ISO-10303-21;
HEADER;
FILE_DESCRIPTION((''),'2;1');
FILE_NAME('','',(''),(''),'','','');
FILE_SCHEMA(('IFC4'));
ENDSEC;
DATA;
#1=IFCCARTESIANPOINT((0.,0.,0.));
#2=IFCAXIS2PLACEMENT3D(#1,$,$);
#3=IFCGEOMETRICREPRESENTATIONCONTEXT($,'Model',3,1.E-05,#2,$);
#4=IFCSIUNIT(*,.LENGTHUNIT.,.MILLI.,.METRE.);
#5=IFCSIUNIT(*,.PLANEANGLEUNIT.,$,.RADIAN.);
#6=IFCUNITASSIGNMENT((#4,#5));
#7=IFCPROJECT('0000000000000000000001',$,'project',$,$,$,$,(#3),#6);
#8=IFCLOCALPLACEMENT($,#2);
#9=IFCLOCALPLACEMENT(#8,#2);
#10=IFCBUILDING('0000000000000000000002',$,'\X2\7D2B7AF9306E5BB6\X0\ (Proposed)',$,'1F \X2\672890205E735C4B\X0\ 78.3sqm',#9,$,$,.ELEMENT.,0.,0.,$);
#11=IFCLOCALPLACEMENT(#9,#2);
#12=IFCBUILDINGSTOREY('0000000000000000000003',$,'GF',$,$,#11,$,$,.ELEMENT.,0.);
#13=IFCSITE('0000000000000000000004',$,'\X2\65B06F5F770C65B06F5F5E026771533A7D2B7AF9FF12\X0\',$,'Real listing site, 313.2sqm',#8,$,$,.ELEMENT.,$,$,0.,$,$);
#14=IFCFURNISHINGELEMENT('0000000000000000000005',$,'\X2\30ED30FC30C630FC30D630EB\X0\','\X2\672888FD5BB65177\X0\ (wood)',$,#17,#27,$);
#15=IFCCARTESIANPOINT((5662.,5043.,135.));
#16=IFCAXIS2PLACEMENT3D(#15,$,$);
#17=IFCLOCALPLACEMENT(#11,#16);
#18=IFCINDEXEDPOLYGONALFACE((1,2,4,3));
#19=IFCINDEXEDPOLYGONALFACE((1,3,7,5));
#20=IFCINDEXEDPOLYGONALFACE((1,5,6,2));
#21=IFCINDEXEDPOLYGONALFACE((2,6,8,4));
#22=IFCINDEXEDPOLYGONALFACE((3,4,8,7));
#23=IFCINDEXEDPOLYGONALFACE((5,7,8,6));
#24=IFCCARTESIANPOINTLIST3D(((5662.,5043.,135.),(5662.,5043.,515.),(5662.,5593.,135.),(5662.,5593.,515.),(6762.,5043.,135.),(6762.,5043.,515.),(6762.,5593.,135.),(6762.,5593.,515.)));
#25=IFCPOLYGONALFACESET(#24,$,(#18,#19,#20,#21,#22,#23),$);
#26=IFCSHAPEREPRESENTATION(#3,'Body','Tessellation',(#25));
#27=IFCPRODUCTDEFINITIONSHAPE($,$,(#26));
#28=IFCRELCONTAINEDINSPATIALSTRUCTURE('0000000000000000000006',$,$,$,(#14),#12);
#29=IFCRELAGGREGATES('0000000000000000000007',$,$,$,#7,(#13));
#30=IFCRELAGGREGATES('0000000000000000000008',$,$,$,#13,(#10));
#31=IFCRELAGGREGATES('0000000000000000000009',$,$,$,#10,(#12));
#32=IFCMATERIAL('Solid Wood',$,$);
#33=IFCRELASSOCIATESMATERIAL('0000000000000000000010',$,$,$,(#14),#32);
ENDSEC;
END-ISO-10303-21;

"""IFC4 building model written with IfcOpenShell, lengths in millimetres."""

from ifc_helpers import new_model, si_unit, frame, frame_2d, origin, place, context, project, spatial, rectangle, extrude, material, element, save


model = new_model("IFC4")

# Units and contexts
model_context = context("Model", 3, precision=1e-05, world=origin())
ifc_project = project(units=[si_unit("LENGTHUNIT", "METRE", prefix="MILLI"), si_unit("PLANEANGLEUNIT", "RADIAN")], contexts=[model_context])

# Site, building, storey
site_placement = place(None, origin())
site = spatial("IfcSite", under=ifc_project, at=site_placement, Name="新潟県新潟市東区紫竹２", ObjectType="Real listing site, 313.2sqm", CompositionType="ELEMENT", RefElevation=0.0)
building_placement = place(site_placement, origin())
building = spatial("IfcBuilding", under=site, at=building_placement, Name="紫竹の家 (Proposed)", ObjectType="1F 木造平屋 78.3sqm", CompositionType="ELEMENT", ElevationOfRefHeight=0.0, ElevationOfTerrain=0.0)
storey_placement = place(building_placement, origin())
storey = spatial("IfcBuildingStorey", under=building, at=storey_placement, Name="GF", CompositionType="ELEMENT", Elevation=0.0)

# Shared definitions
ifc_material_1 = material(Name="Solid Wood")

# Furnishing element
furnishing_1_placement = place(storey_placement, frame((5662.0, 5043.0, 135.0)))
element("IfcFurnishingElement", 1, at=furnishing_1_placement, inside=storey, material=ifc_material_1, Name="ローテーブル", Description="木製家具 (wood)", context=model_context, shape_type="SweptSolid", body=[
    extrude(rectangle(XDim=1100.0, YDim=550.0, at=frame_2d((550.0, 275.0))), frame((5662.0, 5043.0, 135.0)), (0.0, 0.0, 1.0), 380.0),
])

save(model, "model.ifc")
